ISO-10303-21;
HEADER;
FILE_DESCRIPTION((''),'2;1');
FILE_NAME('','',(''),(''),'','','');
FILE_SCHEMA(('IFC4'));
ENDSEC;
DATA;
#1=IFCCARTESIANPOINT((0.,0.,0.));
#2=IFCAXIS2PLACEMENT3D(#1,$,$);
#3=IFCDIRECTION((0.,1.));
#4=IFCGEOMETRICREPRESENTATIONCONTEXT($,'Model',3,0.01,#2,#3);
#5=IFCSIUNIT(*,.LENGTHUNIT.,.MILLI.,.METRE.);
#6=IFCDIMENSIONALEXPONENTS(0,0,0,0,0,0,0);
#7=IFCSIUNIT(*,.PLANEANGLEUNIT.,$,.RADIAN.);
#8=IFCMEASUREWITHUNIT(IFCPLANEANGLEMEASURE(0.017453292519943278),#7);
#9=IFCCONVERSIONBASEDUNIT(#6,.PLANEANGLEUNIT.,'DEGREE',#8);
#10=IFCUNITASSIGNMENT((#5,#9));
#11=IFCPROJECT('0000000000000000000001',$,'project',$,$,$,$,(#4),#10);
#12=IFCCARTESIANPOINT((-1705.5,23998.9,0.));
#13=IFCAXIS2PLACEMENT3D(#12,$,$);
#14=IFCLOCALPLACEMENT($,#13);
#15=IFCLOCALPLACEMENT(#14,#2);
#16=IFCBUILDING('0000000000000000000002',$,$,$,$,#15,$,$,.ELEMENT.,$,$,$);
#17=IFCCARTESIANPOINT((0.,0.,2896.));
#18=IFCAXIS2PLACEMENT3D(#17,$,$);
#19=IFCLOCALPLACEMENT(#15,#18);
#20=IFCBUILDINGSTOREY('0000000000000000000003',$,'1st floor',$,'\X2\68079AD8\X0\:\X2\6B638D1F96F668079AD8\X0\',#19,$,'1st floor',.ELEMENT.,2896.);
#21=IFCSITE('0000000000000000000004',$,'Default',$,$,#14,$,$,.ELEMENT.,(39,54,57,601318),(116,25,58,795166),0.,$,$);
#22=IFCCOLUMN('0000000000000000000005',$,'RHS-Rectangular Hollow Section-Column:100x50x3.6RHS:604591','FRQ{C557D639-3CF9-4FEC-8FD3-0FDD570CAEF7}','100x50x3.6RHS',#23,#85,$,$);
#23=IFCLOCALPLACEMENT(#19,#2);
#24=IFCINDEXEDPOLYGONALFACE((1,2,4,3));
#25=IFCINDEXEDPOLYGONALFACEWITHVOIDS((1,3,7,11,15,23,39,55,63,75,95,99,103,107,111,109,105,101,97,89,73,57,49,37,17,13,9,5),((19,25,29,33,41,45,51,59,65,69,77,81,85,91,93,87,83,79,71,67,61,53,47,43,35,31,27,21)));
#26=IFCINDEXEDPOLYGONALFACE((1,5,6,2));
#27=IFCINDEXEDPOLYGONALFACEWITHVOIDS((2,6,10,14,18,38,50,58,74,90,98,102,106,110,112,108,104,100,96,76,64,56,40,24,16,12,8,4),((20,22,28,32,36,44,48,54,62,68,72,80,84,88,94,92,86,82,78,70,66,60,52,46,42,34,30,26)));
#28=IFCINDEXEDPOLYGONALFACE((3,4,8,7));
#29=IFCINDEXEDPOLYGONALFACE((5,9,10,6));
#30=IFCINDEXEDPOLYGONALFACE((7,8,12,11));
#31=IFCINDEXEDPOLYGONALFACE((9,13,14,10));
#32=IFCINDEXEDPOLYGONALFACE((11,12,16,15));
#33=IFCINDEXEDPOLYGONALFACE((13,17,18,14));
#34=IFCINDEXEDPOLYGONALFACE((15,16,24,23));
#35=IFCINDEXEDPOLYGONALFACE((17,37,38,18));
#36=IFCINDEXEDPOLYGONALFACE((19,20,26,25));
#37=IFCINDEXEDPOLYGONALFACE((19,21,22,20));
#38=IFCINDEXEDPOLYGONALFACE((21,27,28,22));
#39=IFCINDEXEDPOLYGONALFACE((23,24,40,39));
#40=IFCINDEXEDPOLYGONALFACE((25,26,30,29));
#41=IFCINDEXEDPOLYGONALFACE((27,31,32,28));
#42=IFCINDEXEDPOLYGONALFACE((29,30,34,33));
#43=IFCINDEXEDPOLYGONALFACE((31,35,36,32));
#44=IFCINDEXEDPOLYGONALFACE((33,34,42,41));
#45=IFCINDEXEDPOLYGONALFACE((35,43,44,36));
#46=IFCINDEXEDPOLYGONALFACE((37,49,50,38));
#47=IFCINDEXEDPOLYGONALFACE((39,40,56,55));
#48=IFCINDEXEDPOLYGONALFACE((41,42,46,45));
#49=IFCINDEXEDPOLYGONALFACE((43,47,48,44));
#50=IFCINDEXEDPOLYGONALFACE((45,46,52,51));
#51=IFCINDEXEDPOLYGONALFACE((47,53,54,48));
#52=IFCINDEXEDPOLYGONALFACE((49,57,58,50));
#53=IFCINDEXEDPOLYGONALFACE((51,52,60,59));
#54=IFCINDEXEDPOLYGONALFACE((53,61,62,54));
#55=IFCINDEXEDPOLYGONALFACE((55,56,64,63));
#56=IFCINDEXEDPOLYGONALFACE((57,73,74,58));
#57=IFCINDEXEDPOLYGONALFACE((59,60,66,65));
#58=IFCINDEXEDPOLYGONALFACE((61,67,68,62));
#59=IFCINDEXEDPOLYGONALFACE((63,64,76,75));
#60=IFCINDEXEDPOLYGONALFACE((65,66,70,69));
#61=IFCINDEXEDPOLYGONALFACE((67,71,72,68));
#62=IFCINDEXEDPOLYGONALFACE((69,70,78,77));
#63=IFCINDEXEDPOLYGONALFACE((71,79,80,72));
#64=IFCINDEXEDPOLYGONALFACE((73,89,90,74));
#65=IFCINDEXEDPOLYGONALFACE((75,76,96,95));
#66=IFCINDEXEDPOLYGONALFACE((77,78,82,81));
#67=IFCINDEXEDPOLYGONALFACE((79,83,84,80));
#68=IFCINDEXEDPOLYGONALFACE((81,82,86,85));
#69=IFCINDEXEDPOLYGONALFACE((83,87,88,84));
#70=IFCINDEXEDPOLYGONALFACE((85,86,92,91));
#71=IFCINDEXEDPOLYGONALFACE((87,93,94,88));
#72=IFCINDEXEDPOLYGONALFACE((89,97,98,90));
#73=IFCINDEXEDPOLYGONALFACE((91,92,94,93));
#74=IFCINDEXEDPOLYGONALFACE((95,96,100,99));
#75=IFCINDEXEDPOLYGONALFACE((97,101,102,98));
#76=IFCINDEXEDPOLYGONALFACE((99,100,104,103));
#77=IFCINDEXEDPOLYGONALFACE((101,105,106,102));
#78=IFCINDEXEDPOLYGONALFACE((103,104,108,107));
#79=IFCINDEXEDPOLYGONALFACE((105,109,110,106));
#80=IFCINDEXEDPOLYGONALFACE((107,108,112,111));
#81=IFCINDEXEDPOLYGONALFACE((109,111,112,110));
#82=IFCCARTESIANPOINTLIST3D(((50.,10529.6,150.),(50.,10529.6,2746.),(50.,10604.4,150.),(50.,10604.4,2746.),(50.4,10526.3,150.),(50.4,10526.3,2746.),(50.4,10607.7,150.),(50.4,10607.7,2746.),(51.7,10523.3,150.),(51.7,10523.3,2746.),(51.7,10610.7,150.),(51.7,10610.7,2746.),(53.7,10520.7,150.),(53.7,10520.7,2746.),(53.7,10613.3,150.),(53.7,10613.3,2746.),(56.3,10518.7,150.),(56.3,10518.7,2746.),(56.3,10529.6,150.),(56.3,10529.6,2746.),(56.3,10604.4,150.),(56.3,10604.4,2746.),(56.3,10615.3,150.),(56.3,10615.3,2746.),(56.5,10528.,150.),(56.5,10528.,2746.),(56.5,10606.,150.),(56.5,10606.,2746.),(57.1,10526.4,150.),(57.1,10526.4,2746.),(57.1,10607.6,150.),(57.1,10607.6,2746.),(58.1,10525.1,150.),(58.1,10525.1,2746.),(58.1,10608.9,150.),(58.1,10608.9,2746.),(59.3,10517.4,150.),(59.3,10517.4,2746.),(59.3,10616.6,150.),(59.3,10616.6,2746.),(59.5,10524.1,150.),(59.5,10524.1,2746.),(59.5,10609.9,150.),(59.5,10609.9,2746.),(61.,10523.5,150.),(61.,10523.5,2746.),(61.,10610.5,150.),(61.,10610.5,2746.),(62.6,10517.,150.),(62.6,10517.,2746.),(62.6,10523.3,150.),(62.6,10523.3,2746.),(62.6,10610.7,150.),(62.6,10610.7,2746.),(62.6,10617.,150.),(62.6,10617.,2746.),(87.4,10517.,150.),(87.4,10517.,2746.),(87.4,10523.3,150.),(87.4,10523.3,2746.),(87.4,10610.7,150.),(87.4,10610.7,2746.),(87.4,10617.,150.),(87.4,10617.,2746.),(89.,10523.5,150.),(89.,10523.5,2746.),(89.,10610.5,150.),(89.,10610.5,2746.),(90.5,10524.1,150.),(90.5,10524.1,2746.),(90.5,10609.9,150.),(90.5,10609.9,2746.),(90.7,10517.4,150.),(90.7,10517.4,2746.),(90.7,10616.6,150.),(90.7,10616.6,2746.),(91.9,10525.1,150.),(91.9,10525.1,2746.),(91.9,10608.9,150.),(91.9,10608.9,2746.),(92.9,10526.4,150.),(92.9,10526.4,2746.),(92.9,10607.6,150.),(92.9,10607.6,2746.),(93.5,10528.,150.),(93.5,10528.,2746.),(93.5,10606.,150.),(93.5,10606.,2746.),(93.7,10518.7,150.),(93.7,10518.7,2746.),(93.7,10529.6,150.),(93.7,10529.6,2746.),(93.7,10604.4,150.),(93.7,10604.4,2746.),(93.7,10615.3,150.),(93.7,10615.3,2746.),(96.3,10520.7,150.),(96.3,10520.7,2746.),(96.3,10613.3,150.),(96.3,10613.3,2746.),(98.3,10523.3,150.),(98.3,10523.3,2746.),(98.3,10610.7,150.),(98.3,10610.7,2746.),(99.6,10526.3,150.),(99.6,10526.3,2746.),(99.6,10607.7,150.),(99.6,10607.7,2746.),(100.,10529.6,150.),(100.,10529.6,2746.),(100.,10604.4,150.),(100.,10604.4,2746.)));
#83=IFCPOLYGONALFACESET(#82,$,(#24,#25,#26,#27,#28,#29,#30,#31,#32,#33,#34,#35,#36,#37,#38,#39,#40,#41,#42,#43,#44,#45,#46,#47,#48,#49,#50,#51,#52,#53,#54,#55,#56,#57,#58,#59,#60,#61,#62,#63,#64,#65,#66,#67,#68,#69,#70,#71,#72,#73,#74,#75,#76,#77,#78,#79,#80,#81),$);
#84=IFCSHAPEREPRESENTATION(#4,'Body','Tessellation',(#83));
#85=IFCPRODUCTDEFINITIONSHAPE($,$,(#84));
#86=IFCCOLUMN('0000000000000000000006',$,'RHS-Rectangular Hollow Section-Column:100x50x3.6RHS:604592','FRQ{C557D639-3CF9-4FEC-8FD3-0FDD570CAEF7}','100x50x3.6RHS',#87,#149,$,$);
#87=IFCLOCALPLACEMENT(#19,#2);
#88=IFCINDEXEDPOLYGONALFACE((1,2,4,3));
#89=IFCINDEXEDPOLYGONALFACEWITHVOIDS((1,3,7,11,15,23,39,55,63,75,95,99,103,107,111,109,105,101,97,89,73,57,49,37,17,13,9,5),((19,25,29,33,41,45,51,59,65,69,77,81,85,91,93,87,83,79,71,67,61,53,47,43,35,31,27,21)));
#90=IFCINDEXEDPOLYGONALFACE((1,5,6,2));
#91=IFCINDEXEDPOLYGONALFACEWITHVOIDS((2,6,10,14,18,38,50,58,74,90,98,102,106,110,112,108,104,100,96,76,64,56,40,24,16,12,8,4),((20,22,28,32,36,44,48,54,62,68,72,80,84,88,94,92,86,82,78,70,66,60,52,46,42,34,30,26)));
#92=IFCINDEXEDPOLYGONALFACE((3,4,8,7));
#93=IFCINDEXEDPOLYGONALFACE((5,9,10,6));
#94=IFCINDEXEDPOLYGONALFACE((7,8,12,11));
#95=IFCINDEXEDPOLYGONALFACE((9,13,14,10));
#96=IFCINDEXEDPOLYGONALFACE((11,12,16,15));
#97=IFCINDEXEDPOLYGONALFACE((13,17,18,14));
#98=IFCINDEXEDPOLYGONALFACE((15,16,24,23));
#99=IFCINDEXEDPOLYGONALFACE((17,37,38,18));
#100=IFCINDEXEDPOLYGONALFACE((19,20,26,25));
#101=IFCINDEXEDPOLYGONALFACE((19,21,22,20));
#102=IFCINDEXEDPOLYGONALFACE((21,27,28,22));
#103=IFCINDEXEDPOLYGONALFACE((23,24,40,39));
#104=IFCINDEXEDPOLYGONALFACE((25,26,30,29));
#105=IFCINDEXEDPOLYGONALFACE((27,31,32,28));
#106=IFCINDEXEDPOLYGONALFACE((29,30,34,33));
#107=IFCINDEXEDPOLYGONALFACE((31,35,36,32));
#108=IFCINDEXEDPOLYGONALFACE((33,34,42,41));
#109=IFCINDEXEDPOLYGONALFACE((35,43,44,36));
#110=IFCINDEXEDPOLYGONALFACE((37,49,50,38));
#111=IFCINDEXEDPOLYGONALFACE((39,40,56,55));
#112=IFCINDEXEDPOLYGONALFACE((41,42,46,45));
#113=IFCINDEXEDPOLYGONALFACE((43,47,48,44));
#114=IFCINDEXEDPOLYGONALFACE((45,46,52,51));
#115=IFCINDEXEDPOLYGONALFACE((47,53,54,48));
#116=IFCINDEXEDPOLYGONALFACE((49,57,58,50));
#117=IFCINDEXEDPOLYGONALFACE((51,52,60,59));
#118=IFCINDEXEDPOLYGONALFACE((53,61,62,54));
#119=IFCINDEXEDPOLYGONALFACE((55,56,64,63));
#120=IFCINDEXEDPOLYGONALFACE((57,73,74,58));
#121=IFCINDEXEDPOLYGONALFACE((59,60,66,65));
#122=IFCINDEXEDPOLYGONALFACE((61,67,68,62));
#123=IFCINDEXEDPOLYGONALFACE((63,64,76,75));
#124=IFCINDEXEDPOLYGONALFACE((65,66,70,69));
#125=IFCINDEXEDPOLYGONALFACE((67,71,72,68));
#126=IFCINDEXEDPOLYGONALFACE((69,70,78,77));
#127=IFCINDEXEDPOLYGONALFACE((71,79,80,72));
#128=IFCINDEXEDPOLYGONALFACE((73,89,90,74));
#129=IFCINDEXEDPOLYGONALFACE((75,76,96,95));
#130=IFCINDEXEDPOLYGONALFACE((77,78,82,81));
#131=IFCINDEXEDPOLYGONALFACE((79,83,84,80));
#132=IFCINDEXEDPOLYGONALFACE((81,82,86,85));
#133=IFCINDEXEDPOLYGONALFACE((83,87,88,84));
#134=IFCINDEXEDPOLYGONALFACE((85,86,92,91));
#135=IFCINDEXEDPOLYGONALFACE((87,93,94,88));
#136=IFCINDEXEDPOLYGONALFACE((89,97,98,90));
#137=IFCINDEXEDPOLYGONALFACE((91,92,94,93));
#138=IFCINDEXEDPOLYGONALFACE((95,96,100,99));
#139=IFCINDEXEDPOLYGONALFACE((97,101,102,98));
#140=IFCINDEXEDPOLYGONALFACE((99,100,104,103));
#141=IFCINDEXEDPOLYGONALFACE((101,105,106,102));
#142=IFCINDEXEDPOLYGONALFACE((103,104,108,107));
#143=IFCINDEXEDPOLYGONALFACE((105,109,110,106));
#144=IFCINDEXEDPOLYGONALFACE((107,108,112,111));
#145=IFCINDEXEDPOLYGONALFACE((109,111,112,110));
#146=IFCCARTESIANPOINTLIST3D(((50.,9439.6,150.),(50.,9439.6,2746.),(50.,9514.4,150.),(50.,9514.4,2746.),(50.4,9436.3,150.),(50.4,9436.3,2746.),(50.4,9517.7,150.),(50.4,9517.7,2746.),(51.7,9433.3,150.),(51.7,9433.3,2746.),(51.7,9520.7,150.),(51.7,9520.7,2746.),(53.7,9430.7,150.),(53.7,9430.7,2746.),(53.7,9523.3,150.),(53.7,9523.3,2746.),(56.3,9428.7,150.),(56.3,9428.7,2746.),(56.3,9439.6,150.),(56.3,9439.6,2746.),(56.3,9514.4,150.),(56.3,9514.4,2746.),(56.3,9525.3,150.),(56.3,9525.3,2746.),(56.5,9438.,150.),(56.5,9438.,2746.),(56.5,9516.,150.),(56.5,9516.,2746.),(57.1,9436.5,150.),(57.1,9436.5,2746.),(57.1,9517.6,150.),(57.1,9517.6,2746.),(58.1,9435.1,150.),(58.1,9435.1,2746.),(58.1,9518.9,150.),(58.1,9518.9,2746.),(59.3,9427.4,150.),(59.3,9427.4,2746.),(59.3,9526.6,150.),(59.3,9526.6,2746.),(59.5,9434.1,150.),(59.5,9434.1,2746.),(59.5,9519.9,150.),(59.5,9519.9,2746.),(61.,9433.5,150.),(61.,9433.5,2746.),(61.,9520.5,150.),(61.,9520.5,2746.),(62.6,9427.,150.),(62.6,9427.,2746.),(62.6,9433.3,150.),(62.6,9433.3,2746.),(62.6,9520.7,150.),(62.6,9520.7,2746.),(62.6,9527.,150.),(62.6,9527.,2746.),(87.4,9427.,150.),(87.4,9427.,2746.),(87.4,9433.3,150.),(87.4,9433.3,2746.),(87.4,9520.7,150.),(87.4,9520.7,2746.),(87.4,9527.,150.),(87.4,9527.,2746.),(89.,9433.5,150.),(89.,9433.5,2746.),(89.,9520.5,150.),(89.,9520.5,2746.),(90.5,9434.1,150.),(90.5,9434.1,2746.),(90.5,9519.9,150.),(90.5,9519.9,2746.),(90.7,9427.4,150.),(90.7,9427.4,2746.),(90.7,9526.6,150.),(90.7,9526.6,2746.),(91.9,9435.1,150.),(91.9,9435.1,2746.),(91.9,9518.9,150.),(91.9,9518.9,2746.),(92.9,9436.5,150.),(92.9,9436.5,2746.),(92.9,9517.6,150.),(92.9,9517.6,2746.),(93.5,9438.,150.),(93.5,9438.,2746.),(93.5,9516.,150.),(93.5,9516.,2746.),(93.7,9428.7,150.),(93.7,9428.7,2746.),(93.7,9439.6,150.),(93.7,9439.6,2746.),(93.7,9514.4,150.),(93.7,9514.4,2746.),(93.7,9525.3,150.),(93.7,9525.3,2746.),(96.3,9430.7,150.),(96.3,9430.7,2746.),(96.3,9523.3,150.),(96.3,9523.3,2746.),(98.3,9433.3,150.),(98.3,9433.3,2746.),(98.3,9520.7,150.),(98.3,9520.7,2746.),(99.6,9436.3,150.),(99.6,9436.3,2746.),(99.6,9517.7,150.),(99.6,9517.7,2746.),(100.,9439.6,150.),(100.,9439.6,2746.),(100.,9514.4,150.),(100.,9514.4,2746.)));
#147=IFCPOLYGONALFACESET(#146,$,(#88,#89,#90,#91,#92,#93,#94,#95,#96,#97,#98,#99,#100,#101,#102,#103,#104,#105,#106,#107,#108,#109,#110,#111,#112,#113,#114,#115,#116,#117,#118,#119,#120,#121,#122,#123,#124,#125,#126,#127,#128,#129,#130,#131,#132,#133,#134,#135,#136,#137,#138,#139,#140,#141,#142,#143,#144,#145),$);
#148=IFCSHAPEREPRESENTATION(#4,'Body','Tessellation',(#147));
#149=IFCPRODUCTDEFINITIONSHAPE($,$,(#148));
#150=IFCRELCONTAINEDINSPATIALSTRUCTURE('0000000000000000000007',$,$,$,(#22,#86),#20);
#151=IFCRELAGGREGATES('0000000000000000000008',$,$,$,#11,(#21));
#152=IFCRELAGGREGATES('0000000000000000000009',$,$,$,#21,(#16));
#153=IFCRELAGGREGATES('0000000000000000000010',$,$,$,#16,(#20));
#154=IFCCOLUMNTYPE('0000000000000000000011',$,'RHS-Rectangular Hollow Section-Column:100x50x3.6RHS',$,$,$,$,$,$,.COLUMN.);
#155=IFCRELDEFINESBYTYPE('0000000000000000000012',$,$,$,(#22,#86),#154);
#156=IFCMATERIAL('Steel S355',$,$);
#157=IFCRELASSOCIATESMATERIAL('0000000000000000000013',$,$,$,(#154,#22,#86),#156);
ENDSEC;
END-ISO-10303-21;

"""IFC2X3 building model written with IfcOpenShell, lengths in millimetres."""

from ifc_helpers import new_model, entity, si_unit, converted_unit, direction, frame, origin, origin_2d, place, context, project, spatial, hollow_rectangle, extrude, clip, halfspace, material, type_object, element, save


model = new_model("IFC2X3")

# Units and contexts
model_context = context("Model", 3, precision=0.01, world=origin(), true_north=direction((0.0, 1.0)))
ifc_project = project(units=[si_unit("LENGTHUNIT", "METRE", prefix="MILLI"), converted_unit("PLANEANGLEUNIT", "DEGREE", entity("IfcPlaneAngleMeasure", 0.017453292519943278), si_unit("PLANEANGLEUNIT", "RADIAN"), dimensions=[0, 0, 0, 0, 0, 0, 0])], contexts=[model_context])

# Site, building, storey
site_placement = place(None, frame((-1705.5, 23998.9, 0.0)))
site = spatial("IfcSite", under=ifc_project, at=site_placement, Name="Default", CompositionType="ELEMENT", RefLatitude=(39, 54, 57, 601318), RefLongitude=(116, 25, 58, 795166), RefElevation=0.0)
building_placement = place(site_placement, origin())
building = spatial("IfcBuilding", under=site, at=building_placement, CompositionType="ELEMENT")
storey_placement = place(building_placement, frame((0.0, 0.0, 2896.0)))
storey = spatial("IfcBuildingStorey", under=building, at=storey_placement, Name="1st floor", ObjectType="标高:正负零标高", LongName="1st floor", CompositionType="ELEMENT", Elevation=2896.0)

# Columns
ifc_material_1 = material(Name="Steel S355")
column_type_1 = type_object("IfcColumnType", Name="RHS-Rectangular Hollow Section-Column:100x50x3.6RHS", PredefinedType="COLUMN", material=ifc_material_1)
column_1_placement = place(storey_placement, frame((75.0, 10567.0, 2746.0), z_axis=(0.0, 0.0, 1.0), x_axis=(-1.0, 0.0, 0.0)))
element("IfcColumn", 1, at=column_1_placement, inside=storey, type_object=column_type_1, material=ifc_material_1, Name="RHS-Rectangular Hollow Section-Column:100x50x3.6RHS:604591", Description="FRQ{C557D639-3CF9-4FEC-8FD3-0FDD570CAEF7}", ObjectType="100x50x3.6RHS", context=model_context, shape_type="Clipping", body=[
    clip(extrude(hollow_rectangle(XDim=50.0, YDim=100.0, WallThickness=6.3, InnerFilletRadius=6.3, OuterFilletRadius=12.6, at=origin_2d()), origin(), (0.0, 0.0, -1.0), 2651.9), halfspace(frame((75.0, 10567.0, -2596.0), z_axis=(0.0, 0.0, 1.0), x_axis=(-1.0, 0.0, 0.0)), True)),
])
column_2_placement = place(storey_placement, frame((75.0, 9477.0, 2746.0), z_axis=(0.0, 0.0, 1.0), x_axis=(-1.0, 0.0, 0.0)))
element("IfcColumn", 2, at=column_2_placement, inside=storey, type_object=column_type_1, material=ifc_material_1, Name="RHS-Rectangular Hollow Section-Column:100x50x3.6RHS:604592", Description="FRQ{C557D639-3CF9-4FEC-8FD3-0FDD570CAEF7}", ObjectType="100x50x3.6RHS", context=model_context, shape_type="Clipping", body=[
    clip(extrude(hollow_rectangle(XDim=50.0, YDim=100.0, WallThickness=6.3, InnerFilletRadius=6.3, OuterFilletRadius=12.6, at=origin_2d()), origin(), (0.0, 0.0, -1.0), 2651.9), halfspace(frame((75.0, 9477.0, -2596.0), z_axis=(0.0, 0.0, 1.0), x_axis=(-1.0, 0.0, 0.0)), True)),
])

save(model, "model.ifc")
